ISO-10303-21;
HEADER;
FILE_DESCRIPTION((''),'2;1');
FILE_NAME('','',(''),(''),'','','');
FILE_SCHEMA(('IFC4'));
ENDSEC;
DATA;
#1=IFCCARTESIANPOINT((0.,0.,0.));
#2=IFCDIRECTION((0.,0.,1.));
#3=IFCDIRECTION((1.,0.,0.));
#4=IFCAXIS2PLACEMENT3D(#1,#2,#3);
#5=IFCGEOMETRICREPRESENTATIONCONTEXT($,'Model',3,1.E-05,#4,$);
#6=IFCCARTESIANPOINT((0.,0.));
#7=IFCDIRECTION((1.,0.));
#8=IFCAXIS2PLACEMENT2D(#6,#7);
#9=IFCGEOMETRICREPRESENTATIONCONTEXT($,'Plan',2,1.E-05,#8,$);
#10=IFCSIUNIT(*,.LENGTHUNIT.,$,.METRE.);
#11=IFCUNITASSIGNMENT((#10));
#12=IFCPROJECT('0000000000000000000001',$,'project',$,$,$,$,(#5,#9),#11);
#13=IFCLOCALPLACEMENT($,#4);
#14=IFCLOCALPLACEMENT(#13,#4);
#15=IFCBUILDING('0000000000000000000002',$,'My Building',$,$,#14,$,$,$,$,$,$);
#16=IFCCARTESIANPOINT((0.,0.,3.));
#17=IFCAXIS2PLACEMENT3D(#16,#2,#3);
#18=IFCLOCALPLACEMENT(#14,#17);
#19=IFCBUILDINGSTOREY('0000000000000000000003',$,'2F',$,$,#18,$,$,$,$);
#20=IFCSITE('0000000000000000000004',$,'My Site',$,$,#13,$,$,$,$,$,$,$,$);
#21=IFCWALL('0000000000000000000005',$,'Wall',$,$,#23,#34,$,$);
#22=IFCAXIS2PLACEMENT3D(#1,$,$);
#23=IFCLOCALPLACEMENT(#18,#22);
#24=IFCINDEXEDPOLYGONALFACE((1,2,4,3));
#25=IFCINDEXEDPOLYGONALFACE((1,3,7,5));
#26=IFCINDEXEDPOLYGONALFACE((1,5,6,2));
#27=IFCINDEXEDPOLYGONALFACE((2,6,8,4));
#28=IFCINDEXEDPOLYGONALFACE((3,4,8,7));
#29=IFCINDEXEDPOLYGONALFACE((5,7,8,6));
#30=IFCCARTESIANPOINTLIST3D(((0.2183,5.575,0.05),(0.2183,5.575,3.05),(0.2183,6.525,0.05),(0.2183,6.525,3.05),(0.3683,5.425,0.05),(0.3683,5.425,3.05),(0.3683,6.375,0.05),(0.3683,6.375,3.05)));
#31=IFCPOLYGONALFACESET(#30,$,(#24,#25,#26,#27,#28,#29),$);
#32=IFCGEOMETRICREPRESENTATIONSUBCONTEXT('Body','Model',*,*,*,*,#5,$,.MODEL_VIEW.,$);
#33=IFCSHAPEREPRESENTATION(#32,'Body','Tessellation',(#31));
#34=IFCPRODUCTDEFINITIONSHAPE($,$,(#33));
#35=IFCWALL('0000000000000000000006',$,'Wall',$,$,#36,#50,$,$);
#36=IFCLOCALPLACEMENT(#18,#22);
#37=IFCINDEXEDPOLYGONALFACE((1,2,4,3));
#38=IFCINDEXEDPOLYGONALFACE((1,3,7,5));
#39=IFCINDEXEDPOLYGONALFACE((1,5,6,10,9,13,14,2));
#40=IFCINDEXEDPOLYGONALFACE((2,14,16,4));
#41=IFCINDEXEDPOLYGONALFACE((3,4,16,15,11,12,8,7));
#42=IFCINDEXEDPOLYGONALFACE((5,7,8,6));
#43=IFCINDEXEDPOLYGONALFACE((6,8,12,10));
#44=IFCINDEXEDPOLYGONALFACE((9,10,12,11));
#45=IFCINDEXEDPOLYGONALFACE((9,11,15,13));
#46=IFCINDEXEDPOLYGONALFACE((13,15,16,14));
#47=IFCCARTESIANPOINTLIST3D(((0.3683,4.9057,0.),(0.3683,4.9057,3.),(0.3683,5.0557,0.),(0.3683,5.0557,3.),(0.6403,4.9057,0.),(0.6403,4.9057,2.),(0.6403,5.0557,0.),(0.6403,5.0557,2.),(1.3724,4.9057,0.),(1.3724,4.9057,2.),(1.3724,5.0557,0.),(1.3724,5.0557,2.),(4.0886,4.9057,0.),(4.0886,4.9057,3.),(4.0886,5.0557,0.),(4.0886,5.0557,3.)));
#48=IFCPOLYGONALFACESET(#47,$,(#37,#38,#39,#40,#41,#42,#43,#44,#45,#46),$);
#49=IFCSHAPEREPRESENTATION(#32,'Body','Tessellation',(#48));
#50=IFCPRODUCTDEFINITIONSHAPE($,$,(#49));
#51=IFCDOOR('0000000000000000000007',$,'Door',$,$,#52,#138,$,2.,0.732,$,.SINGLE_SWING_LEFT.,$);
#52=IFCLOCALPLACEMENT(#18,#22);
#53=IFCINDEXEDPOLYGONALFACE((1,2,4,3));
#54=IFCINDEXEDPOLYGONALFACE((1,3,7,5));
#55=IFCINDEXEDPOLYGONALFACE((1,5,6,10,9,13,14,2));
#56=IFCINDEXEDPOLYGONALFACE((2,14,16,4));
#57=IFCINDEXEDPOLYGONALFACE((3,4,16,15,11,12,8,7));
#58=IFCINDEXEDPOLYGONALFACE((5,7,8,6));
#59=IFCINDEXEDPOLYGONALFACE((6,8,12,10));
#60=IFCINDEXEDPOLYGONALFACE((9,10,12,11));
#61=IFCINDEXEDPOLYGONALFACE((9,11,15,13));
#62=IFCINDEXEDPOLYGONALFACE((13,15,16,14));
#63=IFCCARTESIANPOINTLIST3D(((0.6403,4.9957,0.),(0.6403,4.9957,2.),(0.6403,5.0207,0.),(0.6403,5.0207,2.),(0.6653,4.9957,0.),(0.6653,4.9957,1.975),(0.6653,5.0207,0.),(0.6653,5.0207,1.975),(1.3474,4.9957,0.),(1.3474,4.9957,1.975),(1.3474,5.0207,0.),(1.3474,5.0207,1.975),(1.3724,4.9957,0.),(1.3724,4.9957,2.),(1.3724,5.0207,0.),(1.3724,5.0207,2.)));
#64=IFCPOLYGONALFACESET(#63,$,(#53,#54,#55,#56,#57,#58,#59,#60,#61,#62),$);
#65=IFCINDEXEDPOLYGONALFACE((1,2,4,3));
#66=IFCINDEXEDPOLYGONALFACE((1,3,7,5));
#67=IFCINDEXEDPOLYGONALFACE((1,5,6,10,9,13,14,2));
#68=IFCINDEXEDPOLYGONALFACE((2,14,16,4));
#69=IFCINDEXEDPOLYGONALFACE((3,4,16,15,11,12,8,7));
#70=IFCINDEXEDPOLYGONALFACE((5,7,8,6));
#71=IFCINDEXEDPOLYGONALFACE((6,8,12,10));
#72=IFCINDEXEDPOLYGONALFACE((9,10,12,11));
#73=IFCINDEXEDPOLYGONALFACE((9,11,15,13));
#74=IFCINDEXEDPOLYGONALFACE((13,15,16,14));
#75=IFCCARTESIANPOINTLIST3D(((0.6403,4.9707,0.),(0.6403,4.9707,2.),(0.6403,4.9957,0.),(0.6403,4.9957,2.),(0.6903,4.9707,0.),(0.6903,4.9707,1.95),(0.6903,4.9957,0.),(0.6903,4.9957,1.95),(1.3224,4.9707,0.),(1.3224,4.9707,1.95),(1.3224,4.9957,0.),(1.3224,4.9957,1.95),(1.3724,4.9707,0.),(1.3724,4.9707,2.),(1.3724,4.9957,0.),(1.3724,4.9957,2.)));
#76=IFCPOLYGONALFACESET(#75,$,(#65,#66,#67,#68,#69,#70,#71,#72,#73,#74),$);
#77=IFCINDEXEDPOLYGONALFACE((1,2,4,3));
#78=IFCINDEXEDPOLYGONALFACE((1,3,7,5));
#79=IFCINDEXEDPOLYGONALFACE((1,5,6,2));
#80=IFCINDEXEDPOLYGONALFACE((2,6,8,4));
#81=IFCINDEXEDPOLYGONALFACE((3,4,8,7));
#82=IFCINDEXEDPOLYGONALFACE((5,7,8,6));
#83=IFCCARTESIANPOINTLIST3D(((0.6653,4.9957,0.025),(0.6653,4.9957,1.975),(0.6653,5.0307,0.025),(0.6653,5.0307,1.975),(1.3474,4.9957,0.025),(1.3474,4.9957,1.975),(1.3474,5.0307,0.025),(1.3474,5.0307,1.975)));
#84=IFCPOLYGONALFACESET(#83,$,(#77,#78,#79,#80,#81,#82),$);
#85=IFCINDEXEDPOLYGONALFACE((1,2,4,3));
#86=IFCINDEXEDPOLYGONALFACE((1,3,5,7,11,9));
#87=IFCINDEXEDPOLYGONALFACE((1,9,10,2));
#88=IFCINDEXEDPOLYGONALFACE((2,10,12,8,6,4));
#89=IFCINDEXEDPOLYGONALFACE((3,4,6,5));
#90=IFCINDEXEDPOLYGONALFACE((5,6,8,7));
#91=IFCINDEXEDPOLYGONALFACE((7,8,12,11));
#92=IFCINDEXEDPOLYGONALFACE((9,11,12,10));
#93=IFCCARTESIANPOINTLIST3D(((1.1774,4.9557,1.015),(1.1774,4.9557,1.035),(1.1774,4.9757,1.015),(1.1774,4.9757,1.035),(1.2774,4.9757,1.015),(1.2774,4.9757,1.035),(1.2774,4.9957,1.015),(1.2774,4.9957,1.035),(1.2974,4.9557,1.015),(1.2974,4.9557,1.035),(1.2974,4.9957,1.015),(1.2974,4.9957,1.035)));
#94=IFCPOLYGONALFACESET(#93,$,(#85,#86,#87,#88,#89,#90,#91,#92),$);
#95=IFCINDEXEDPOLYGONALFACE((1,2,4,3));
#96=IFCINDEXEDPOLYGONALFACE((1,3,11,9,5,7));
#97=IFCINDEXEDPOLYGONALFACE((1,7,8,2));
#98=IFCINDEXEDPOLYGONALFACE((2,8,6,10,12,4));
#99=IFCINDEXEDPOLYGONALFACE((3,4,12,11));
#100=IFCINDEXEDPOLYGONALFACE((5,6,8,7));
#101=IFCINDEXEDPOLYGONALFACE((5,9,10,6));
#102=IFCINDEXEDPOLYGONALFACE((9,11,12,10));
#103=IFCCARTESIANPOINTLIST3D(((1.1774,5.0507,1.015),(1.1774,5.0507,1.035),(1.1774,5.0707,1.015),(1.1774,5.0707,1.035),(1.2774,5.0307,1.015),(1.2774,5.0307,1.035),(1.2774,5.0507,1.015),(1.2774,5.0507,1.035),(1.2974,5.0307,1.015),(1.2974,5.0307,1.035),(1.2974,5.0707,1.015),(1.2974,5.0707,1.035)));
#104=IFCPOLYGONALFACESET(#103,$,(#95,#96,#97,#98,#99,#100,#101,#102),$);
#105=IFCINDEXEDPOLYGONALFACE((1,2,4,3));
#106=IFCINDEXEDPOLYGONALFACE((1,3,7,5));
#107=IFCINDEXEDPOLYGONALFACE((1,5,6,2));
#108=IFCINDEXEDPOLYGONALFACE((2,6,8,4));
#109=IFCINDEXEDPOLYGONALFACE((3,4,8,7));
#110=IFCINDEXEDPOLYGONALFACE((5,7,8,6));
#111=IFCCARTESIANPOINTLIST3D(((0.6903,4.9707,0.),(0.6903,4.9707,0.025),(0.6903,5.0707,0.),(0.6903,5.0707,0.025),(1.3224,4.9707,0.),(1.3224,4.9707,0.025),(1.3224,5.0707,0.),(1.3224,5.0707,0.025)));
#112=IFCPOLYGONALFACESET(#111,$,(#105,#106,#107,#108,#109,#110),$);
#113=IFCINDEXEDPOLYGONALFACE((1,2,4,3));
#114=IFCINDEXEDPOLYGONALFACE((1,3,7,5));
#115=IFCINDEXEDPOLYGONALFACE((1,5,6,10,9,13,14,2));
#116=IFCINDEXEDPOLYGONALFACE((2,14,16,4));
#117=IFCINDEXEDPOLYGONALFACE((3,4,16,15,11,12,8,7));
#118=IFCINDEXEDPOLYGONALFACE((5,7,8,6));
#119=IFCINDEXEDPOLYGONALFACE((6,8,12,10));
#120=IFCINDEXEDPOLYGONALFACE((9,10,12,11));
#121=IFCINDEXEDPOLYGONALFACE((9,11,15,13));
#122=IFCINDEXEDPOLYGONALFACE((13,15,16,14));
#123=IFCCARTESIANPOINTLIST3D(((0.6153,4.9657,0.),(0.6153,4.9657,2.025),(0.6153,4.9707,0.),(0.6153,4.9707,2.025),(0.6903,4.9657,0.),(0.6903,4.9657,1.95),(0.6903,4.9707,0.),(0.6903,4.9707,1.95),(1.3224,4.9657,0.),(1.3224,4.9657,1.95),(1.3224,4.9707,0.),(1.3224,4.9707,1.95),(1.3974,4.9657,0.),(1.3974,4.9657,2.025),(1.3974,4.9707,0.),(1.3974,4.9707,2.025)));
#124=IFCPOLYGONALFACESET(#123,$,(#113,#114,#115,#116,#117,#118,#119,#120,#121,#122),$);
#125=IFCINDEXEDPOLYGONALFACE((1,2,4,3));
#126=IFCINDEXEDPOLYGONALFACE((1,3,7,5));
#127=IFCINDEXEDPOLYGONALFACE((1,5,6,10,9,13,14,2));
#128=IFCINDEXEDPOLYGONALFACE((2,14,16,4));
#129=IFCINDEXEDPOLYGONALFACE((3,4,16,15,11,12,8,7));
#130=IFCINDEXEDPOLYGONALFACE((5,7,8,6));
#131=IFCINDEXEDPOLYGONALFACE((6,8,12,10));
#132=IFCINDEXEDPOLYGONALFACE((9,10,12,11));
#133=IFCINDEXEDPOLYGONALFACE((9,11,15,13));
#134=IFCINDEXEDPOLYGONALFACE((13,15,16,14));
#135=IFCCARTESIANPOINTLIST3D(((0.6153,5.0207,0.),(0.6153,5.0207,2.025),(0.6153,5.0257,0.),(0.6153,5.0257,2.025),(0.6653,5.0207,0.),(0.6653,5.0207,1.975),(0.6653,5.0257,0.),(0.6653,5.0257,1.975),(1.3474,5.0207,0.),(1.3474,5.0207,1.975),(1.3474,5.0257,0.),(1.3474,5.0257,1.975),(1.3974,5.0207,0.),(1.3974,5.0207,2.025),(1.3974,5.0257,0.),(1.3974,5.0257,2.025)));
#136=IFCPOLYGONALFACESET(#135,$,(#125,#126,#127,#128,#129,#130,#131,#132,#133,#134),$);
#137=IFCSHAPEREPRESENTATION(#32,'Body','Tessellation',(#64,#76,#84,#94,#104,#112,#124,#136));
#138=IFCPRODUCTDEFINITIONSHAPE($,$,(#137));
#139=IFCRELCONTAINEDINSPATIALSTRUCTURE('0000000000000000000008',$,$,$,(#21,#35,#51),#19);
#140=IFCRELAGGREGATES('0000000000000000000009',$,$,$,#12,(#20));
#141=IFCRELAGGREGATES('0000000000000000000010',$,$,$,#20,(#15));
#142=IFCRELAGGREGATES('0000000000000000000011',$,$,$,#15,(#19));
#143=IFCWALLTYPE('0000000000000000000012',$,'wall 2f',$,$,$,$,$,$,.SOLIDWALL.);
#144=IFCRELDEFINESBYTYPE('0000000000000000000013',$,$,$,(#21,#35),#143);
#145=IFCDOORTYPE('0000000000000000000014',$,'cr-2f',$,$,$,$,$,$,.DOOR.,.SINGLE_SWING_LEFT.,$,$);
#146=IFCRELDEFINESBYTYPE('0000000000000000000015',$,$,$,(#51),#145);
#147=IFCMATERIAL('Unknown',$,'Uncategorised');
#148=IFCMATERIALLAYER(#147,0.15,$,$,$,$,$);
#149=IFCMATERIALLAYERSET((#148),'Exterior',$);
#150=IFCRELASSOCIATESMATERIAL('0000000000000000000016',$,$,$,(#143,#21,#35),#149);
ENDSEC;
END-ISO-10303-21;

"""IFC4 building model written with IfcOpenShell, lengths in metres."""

from ifc_helpers import new_model, entity, si_unit, frame, origin_with_axes, origin_2d_with_axis, place, context, subcontext, project, spatial, line, indexed_curve, outline, extrude, shape, source, transform, mapped, material, layer, layer_set, layer_usage, type_object, type_shapes, element, fill, save


model = new_model("IFC4")

# Units and contexts
model_context = context("Model", 3, precision=1e-05, world=origin_with_axes())
plan_context = context("Plan", 2, precision=1e-05, world=origin_2d_with_axis())
body_context_1 = subcontext(model_context, "Body", "Model", "MODEL_VIEW")
body_context_2 = subcontext(plan_context, "Body", "Plan", "PLAN_VIEW")
ifc_project = project(units=[si_unit("LENGTHUNIT", "METRE")], contexts=[model_context, plan_context])

# Site, building, storey
site_placement = place(None, origin_with_axes())
site = spatial("IfcSite", under=ifc_project, at=site_placement, Name="My Site")
building_placement = place(site_placement, origin_with_axes())
building = spatial("IfcBuilding", under=site, at=building_placement, Name="My Building")
storey_placement = place(building_placement, frame((0.0, 0.0, 3.0), z_axis=(0.0, 0.0, 1.0), x_axis=(1.0, 0.0, 0.0)))
storey = spatial("IfcBuildingStorey", under=building, at=storey_placement, Name="2F")

# Shared definitions
ifc_material = material(Name="Unknown", Category="Uncategorised")

# Wall
ifc_layer_1 = layer(ifc_material, 0.15)
ifc_layer_set_1 = layer_set([ifc_layer_1], Name="Exterior")
wall_type_1 = type_object("IfcWallType", Name="wall 2f", PredefinedType="SOLIDWALL", material=ifc_layer_set_1)
ifc_layer_usage_1 = layer_usage(ifc_layer_set_1, "AXIS2", "POSITIVE", 0.0)
wall_1_placement = place(storey_placement, frame((0.2183, 6.525, 0.05), z_axis=(0.0, 0.0, 1.0), x_axis=(0.0, -1.0, 0.0)))
element("IfcWall", 1, at=wall_1_placement, inside=storey, type_object=wall_type_1, material=ifc_layer_usage_1, Name="Wall", context=body_context_1, shape_type="SweptSolid", body=[
    extrude(outline(indexed_curve([(0.0, 0.0), (0.15, 0.15), (1.1, 0.15), (0.95, 0.0)], segments=[line(1, 2, 3, 4, 1)])), origin_with_axes(), (0.0, 0.0, 1.0), 3.0),
])

# Wall, opening, door
ifc_layer_usage_2 = layer_usage(ifc_layer_set_1, "AXIS2", "POSITIVE", 0.0)
wall_2_placement = place(storey_placement, frame((0.3683, 4.9057, 0.0), z_axis=(0.0, 0.0, 1.0), x_axis=(1.0, 0.0, 0.0)))
wall_2 = element("IfcWall", 2, at=wall_2_placement, inside=storey, type_object=wall_type_1, material=ifc_layer_usage_2, Name="Wall", context=body_context_1, shape_type="SweptSolid", body=[
    extrude(outline(indexed_curve([(0.0, 0.0), (0.0, 0.15), (3.7202, 0.15), (3.7202, 0.0)], segments=[line(1, 2, 3, 4, 1)])), origin_with_axes(), (0.0, 0.0, 1.0), 3.0),
])
shared_shape_1 = source(origin_with_axes(), body_context_1, "Body", "SweptSolid", [
    extrude(outline(indexed_curve([(0.0, 0.0), (0.732, 0.0), (0.732, 2.0), (0.0, 2.0)], segments=[line(1, 2, 3, 4, 1)])), frame((0.0, -0.6, 0.0), z_axis=(0.0, -1.0, 0.0), x_axis=(1.0, 0.0, 0.0)), (0.0, 0.0, -1.0), 1.2),
])
opening_1_placement = place(wall_2_placement, frame((0.272, 0.065, 0.0), z_axis=(0.0, 0.0, 1.0), x_axis=(1.0, 0.0, 0.0)))
opening_1 = element("IfcOpeningElement", 3, at=opening_1_placement, cuts=wall_2, PredefinedType="OPENING", context=body_context_1, shape_type="MappedRepresentation", body=[
    mapped(shared_shape_1, transform((0.0, 0.0, 0.0), x_axis=(1.0, 0.0, 0.0), y_axis=(0.0, 1.0, 0.0), z_axis=(0.0, 0.0, 1.0), scale=1.0)),
])
door_type_1 = type_object("IfcDoorType", Name="cr-2f", OperationType="SINGLE_SWING_LEFT", PredefinedType="DOOR")
shared_shape_2 = source(origin_with_axes(), body_context_1, "Body", "SweptSolid", [
    extrude(outline(indexed_curve([(0.0, 0.0), (0.0, 2.0), (0.732, 2.0), (0.732, 0.0), (0.707, 0.0), (0.707, 1.975), (0.025, 1.975), (0.025, 0.0)], segments=[line(1, 2, 3, 4, 5, 6, 7, 8, 1)])), frame((0.0, 0.025, 0.0), z_axis=(0.0, -1.0, 0.0), x_axis=(1.0, 0.0, 0.0)), (0.0, 0.0, -1.0), 0.025),
    extrude(outline(indexed_curve([(0.0, 0.0), (0.0, 2.0), (0.732, 2.0), (0.732, 0.0), (0.682, 0.0), (0.682, 1.95), (0.05, 1.95), (0.05, 0.0)], segments=[line(1, 2, 3, 4, 5, 6, 7, 8, 1)])), frame((0.0, 0.0, 0.0), z_axis=(0.0, -1.0, 0.0), x_axis=(1.0, 0.0, 0.0)), (0.0, 0.0, -1.0), 0.025),
    extrude(outline(indexed_curve([(0.0, 0.0), (0.682, 0.0), (0.682, 0.035), (0.0, 0.035)], segments=[line(1, 2, 3, 4, 1)])), frame((0.025, 0.025, 0.025), z_axis=(0.0, 0.0, 1.0), x_axis=(1.0, 0.0, 0.0)), (0.0, 0.0, 1.0), 1.95),
    extrude(outline(indexed_curve([(0.0, 0.0), (0.0, -0.04), (-0.12, -0.04), (-0.12, -0.02), (-0.02, -0.02), (-0.02, 0.0)], segments=[line(1, 2, 3, 4, 5, 6, 1)])), frame((0.657, 0.025, 1.015), z_axis=(0.0, 0.0, 1.0), x_axis=(1.0, 0.0, 0.0)), (0.0, 0.0, 1.0), 0.02),
    extrude(outline(indexed_curve([(0.0, 0.0), (0.0, 0.04), (-0.12, 0.04), (-0.12, 0.02), (-0.02, 0.02), (-0.02, 0.0)], segments=[line(1, 2, 3, 4, 5, 6, 1)])), frame((0.657, 0.06, 1.015), z_axis=(0.0, 0.0, 1.0), x_axis=(1.0, 0.0, 0.0)), (0.0, 0.0, 1.0), 0.02),
    extrude(outline(indexed_curve([(0.0, 0.0), (0.632, 0.0), (0.632, 0.1), (0.0, 0.1)], segments=[line(1, 2, 3, 4, 1)])), frame((0.05, 0.0, 0.0), z_axis=(0.0, 0.0, 1.0), x_axis=(1.0, 0.0, 0.0)), (0.0, 0.0, 1.0), 0.025),
    extrude(outline(indexed_curve([(0.0, 0.0), (0.0, 2.025), (0.782, 2.025), (0.782, 0.0), (0.707, 0.0), (0.707, 1.95), (0.075, 1.95), (0.075, 0.0)], segments=[line(1, 2, 3, 4, 5, 6, 7, 8, 1)])), frame((-0.025, -0.005, 0.0), z_axis=(0.0, -1.0, 0.0), x_axis=(1.0, 0.0, 0.0)), (0.0, 0.0, -1.0), 0.005),
    extrude(outline(indexed_curve([(0.0, 0.0), (0.0, 2.025), (0.782, 2.025), (0.782, 0.0), (0.732, 0.0), (0.732, 1.975), (0.05, 1.975), (0.05, 0.0)], segments=[line(1, 2, 3, 4, 5, 6, 7, 8, 1)])), frame((-0.025, 0.05, 0.0), z_axis=(0.0, -1.0, 0.0), x_axis=(1.0, 0.0, 0.0)), (0.0, 0.0, -1.0), 0.005),
])
shared_shape_3 = source(origin_with_axes(), body_context_2, "Body", "Curve2D", [
    entity("IfcIndexedPolyCurve", entity("IfcCartesianPointList2D", [[0.0, 0.0], [0.0, 0.05], [0.025, 0.05], [0.025, 0.025], [0.05, 0.025], [0.05, 0.0]]), [entity("IfcLineIndex", [1, 2, 3, 4, 5, 6, 1])]),
    entity("IfcIndexedPolyCurve", entity("IfcCartesianPointList2D", [[0.732, 0.0], [0.732, 0.05], [0.707, 0.05], [0.707, 0.025], [0.682, 0.025], [0.682, 0.0]]), [entity("IfcLineIndex", [1, 2, 3, 4, 5, 6, 1])]),
    entity("IfcTrimmedCurve", entity("IfcEllipse", entity("IfcAxis2Placement2D", entity("IfcCartesianPoint", [0.06, 0.05]), entity("IfcDirection", [1.0, 0.0])), 0.647, 0.682), [entity("IfcCartesianPoint", [0.707, 0.05])], [entity("IfcCartesianPoint", [0.06, 0.732])], True, "CARTESIAN"),
    entity("IfcIndexedPolyCurve", entity("IfcCartesianPointList2D", [[0.025, 0.05], [0.06, 0.05], [0.06, 0.732], [0.025, 0.732]]), [entity("IfcLineIndex", [1, 2, 3, 4, 1])]),
])
type_shapes(door_type_1, [shared_shape_2, shared_shape_3])
door_1_placement = place(opening_1_placement, frame((0.0, 0.0, 0.0), z_axis=(0.0, 0.0, 1.0), x_axis=(1.0, 0.0, 0.0)))
door_1 = element("IfcDoor", 4, at=door_1_placement, inside=storey, type_object=door_type_1, Name="Door", OperationType="SINGLE_SWING_LEFT", OverallHeight=2.0, OverallWidth=0.732, shapes=[
    shape(body_context_1, "Body", "MappedRepresentation", [mapped(shared_shape_2, transform((0.0, 0.0, 0.0), x_axis=(1.0, 0.0, 0.0), y_axis=(0.0, 1.0, 0.0), z_axis=(0.0, 0.0, 1.0), scale=1.0))]),
    shape(body_context_2, "Body", "MappedRepresentation", [mapped(shared_shape_3, transform((0.0, 0.0, 0.0), x_axis=(1.0, 0.0, 0.0), y_axis=(0.0, 1.0, 0.0), z_axis=(0.0, 0.0, 1.0), scale=1.0))]),
])
fill(opening_1, door_1)

save(model, "model.ifc")
